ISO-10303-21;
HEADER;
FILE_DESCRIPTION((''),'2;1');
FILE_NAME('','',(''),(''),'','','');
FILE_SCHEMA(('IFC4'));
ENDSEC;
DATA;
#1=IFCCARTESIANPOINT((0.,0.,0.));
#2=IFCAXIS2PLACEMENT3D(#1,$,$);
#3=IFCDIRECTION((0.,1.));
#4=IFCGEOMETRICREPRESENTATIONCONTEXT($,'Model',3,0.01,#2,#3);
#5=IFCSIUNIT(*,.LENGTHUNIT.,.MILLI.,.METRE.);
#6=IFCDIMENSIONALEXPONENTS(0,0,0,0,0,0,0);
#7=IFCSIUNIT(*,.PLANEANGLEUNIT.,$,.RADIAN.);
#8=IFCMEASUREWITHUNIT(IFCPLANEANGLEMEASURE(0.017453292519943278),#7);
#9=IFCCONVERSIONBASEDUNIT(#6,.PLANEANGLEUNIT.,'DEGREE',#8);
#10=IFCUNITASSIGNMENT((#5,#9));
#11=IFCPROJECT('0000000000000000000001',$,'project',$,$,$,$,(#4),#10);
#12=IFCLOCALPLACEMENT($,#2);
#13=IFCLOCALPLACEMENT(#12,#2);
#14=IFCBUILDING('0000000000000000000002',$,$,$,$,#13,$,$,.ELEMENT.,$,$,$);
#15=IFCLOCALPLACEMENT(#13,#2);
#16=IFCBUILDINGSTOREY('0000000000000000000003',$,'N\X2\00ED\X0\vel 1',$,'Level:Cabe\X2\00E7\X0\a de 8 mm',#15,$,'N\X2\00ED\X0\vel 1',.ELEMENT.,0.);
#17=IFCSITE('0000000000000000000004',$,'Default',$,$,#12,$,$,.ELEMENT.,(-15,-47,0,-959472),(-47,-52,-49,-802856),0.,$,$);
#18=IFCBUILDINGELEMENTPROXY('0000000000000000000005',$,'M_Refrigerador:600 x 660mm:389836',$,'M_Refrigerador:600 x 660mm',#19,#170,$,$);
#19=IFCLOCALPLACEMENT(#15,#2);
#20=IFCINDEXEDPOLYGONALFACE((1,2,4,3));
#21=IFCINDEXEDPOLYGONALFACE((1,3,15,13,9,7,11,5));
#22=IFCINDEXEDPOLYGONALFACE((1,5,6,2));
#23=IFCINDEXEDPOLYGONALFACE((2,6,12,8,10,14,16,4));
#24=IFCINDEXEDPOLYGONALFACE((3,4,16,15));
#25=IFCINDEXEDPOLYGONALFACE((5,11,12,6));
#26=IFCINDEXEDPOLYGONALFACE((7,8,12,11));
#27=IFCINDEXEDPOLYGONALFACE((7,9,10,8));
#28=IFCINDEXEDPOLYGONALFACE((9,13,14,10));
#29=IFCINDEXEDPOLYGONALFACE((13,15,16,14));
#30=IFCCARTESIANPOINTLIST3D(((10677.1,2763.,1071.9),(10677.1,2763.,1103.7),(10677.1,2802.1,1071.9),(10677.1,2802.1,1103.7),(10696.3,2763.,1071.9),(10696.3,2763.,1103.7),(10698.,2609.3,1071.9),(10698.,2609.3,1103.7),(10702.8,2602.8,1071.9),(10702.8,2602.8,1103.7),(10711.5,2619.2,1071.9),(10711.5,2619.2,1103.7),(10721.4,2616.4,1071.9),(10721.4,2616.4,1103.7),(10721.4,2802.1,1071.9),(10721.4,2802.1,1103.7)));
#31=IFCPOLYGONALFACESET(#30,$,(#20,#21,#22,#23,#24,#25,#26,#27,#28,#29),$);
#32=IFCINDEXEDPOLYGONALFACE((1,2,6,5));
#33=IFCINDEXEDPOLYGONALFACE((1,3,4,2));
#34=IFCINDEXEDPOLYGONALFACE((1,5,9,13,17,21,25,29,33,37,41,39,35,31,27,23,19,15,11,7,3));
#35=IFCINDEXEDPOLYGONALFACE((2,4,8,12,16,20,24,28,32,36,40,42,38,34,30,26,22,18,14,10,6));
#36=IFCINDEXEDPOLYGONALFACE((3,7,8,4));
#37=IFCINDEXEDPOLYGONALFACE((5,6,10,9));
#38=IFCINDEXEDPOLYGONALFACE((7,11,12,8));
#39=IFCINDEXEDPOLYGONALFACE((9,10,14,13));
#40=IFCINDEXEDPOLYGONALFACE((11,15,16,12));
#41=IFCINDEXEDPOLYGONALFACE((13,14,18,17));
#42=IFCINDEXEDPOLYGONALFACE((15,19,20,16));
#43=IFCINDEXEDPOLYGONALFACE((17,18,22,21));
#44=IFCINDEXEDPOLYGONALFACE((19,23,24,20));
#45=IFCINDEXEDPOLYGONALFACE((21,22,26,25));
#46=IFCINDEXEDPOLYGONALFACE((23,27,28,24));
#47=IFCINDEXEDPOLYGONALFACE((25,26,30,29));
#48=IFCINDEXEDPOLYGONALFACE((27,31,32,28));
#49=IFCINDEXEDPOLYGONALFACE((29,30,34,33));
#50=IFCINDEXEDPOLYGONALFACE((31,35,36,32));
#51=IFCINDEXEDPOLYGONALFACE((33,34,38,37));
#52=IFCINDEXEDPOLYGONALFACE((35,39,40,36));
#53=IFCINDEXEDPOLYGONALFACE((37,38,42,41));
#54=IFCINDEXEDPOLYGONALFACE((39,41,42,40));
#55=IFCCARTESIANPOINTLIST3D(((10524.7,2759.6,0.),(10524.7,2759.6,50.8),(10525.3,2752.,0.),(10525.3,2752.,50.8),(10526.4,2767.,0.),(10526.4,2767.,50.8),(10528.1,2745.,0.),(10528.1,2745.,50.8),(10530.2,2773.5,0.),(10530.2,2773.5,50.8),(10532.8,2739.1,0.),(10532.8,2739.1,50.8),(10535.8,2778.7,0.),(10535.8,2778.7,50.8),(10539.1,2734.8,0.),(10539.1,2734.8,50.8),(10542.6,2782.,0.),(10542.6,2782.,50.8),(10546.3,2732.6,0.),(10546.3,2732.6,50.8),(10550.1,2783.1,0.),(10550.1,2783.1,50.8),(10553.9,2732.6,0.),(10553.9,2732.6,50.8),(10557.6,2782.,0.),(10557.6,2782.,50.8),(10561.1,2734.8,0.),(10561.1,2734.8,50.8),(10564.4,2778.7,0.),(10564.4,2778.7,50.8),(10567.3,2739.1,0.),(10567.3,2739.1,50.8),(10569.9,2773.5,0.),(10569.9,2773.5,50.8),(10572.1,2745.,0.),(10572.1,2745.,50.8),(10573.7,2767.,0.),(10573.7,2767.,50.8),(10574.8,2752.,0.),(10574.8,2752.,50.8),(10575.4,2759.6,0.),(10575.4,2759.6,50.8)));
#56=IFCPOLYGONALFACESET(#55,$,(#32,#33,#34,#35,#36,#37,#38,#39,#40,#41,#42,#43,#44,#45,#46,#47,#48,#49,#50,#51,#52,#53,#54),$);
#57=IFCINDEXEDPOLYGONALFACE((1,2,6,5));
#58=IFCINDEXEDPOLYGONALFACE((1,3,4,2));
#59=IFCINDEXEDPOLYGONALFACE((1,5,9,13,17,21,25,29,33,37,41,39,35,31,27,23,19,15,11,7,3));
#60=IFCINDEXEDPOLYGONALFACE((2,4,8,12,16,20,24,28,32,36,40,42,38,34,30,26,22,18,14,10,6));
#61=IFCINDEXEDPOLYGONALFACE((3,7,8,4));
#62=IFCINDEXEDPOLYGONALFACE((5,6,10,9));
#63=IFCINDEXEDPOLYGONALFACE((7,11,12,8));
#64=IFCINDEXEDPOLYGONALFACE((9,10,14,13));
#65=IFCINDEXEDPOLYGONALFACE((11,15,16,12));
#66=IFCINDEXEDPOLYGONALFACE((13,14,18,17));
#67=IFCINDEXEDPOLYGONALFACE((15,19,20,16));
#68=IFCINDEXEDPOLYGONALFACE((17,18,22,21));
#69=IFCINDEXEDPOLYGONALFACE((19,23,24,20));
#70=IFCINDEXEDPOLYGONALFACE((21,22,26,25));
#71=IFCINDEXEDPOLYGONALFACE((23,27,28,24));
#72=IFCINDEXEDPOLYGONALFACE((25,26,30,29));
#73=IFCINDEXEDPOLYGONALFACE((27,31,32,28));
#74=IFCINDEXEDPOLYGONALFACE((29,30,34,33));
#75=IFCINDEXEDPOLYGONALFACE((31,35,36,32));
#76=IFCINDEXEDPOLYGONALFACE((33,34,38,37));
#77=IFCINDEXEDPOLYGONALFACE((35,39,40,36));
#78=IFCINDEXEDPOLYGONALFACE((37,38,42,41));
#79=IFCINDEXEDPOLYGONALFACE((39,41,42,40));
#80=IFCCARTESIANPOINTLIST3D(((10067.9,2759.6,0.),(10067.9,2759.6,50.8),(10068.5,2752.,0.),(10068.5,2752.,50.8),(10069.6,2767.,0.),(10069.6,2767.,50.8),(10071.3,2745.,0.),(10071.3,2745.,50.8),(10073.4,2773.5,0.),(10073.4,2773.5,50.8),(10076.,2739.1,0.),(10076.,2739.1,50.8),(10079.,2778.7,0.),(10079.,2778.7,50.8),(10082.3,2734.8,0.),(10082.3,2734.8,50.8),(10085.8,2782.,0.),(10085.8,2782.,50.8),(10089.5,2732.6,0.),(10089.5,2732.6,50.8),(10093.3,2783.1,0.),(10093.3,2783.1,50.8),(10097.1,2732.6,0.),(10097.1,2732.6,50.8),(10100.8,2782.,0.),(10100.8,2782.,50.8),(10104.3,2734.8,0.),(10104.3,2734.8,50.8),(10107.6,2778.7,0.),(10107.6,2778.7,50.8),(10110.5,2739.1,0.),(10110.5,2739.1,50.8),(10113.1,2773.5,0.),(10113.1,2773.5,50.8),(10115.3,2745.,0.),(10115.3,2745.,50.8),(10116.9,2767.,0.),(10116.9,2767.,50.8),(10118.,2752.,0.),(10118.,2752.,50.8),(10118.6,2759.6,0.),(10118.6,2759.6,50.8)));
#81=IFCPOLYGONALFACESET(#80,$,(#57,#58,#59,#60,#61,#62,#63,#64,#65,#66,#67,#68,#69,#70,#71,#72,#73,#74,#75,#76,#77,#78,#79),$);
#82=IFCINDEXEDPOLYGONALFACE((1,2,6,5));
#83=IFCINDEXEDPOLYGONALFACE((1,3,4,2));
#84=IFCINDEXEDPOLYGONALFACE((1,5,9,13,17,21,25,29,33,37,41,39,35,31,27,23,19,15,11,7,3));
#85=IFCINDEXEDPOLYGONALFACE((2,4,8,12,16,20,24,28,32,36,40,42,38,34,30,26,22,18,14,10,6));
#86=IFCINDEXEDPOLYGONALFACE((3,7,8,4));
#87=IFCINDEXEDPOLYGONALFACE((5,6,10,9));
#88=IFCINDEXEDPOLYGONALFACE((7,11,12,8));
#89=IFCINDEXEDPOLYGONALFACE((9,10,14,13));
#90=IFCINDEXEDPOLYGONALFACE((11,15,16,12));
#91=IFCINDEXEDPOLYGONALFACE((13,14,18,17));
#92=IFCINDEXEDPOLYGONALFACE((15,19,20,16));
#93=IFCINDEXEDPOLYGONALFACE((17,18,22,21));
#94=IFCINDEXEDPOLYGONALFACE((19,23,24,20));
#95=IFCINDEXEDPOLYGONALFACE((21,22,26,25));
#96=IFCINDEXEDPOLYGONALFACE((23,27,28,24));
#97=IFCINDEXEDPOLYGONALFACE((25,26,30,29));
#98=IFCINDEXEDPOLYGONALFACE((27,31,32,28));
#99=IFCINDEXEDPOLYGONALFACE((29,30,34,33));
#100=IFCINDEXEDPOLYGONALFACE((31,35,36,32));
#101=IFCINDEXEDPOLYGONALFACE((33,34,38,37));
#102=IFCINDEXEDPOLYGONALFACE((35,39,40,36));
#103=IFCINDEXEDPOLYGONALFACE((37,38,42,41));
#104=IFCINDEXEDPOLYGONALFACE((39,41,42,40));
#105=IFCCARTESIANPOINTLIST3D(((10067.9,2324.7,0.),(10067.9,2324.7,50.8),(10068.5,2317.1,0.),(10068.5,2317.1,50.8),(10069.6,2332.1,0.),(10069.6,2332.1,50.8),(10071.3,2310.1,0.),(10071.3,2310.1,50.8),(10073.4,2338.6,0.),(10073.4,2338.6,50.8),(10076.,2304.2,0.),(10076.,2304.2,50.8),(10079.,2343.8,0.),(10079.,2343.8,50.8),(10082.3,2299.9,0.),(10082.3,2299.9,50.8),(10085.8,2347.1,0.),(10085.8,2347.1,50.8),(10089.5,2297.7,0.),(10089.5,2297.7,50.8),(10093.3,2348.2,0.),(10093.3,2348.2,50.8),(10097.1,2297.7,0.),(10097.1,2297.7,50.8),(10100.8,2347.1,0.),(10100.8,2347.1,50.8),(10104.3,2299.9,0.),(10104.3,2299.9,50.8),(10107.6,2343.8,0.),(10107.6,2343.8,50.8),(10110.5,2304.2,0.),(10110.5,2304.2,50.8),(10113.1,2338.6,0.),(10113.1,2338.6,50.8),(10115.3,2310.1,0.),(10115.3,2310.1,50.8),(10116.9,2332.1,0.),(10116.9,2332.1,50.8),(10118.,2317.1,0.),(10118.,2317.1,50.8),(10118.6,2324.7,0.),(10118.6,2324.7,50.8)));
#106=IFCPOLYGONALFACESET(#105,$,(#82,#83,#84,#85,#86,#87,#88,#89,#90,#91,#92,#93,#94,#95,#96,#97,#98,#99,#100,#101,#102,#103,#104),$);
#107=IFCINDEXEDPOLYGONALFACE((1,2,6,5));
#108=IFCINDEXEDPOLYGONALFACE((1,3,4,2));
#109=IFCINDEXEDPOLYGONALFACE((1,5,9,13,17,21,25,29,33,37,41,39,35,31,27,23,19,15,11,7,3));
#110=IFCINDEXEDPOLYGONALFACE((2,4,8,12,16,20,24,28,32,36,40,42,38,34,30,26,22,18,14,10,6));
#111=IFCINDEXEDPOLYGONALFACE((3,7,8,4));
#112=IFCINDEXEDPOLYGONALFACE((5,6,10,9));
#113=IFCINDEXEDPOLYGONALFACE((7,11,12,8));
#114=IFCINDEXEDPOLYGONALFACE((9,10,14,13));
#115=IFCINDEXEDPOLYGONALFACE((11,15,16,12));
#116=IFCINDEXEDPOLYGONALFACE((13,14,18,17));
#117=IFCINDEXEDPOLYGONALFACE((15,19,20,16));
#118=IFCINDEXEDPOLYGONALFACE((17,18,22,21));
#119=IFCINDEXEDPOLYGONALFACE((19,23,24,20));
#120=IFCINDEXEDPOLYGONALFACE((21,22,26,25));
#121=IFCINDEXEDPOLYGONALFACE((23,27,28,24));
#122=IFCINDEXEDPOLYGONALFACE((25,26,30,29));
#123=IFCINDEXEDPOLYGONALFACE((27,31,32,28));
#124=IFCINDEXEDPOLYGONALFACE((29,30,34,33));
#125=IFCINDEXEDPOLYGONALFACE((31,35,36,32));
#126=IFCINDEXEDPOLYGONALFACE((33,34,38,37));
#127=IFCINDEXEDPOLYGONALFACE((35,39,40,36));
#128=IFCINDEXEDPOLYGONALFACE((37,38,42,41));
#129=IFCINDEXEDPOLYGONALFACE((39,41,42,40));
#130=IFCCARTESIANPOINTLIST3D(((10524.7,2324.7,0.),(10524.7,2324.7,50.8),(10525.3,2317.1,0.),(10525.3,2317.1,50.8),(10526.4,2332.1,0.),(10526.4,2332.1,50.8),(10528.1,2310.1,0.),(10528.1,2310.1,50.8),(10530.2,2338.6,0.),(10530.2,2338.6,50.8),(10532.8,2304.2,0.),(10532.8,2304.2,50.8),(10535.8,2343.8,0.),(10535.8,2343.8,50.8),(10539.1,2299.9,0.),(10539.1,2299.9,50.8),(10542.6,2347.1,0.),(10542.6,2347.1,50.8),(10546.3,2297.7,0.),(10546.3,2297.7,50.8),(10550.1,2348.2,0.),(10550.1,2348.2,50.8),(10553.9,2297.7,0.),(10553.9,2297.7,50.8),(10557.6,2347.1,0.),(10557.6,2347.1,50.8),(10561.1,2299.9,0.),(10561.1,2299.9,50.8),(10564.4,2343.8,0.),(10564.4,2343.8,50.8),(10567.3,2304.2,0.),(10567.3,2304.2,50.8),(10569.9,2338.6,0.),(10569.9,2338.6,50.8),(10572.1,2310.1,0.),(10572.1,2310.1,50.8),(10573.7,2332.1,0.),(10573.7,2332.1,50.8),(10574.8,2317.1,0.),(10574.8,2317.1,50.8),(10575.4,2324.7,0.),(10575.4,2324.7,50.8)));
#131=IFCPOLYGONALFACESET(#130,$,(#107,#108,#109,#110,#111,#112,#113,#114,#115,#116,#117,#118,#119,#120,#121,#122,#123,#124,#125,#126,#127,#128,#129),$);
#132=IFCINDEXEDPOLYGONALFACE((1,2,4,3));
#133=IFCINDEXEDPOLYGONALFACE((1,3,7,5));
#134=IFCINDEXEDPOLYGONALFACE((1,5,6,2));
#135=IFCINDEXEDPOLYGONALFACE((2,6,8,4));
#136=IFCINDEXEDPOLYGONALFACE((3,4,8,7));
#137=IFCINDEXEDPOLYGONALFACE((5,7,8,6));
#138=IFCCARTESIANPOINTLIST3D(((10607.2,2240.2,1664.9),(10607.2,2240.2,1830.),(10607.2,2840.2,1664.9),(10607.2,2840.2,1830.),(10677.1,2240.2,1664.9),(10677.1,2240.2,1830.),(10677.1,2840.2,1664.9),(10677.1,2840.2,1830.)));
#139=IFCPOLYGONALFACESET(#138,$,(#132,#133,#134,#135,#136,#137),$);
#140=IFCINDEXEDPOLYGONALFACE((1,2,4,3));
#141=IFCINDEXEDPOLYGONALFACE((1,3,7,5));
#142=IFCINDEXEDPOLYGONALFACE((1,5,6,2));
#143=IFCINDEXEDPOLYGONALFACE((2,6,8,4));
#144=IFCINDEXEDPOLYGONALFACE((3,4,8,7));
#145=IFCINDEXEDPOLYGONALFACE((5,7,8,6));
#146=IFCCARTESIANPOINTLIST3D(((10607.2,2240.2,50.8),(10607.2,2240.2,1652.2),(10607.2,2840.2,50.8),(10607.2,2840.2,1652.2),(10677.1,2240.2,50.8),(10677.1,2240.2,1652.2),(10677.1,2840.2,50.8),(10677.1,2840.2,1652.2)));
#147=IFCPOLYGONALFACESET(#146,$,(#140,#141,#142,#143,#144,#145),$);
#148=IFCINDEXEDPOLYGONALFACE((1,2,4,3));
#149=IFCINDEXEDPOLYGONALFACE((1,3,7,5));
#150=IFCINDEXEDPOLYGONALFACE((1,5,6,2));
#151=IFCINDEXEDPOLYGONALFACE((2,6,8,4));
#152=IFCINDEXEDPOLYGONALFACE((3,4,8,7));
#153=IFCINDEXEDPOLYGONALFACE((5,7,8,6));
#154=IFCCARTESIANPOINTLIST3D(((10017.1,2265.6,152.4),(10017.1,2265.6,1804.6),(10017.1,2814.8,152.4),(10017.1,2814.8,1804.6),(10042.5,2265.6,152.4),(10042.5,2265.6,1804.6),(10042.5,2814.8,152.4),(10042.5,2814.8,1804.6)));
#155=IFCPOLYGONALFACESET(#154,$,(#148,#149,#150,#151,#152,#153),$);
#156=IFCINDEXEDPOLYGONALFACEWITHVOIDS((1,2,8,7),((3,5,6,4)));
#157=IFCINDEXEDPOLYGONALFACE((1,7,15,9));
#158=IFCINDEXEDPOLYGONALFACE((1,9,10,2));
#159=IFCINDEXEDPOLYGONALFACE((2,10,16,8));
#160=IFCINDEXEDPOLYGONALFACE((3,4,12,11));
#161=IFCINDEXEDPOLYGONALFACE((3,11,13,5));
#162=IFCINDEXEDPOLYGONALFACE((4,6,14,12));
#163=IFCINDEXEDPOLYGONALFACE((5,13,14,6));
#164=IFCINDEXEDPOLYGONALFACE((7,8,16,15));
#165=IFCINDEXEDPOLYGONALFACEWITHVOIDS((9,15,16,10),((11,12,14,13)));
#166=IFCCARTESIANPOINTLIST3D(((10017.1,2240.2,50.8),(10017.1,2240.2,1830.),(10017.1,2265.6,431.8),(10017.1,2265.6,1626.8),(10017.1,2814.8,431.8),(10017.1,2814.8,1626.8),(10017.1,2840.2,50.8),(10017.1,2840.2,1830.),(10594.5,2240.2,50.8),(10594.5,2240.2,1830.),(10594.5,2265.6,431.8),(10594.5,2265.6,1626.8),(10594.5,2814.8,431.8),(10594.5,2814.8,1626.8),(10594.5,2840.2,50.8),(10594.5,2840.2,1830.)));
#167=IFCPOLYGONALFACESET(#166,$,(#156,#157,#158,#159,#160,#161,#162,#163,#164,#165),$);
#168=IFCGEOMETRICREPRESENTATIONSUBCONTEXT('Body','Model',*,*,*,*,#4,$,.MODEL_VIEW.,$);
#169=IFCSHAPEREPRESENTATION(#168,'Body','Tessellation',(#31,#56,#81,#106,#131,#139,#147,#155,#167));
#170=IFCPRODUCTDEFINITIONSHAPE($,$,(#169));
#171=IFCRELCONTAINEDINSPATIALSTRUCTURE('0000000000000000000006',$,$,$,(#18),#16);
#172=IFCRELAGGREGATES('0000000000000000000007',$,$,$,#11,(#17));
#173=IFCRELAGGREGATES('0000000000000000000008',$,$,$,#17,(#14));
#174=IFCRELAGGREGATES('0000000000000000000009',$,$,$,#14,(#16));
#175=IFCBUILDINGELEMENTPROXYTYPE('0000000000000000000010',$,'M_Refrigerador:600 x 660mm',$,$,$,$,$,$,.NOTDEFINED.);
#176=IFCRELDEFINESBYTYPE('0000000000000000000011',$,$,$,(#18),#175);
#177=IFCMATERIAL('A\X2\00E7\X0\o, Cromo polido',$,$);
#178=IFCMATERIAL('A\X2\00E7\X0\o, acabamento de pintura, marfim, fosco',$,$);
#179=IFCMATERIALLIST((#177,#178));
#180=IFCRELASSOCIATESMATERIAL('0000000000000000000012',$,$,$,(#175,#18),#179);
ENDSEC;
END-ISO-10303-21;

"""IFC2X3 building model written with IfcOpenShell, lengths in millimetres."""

from ifc_helpers import new_model, entity, si_unit, converted_unit, direction, frame, frame_2d, origin, origin_2d_with_axis, place, context, subcontext, project, spatial, polyline, rectangle, circle, outline, extrude, source, transform, mapped, material, material_list, type_object, type_shapes, element, save


model = new_model("IFC2X3")

# Units and contexts
model_context = context("Model", 3, precision=0.01, world=origin(), true_north=direction((0.0, 1.0)))
body_context = subcontext(model_context, "Body", "Model", "MODEL_VIEW")
ifc_project = project(units=[si_unit("LENGTHUNIT", "METRE", prefix="MILLI"), converted_unit("PLANEANGLEUNIT", "DEGREE", entity("IfcPlaneAngleMeasure", 0.017453292519943278), si_unit("PLANEANGLEUNIT", "RADIAN"), dimensions=[0, 0, 0, 0, 0, 0, 0])], contexts=[model_context])

# Site, building, storey
site_placement = place(None, origin())
site = spatial("IfcSite", under=ifc_project, at=site_placement, Name="Default", CompositionType="ELEMENT", RefLatitude=(-15, -47, 0, -959472), RefLongitude=(-47, -52, -49, -802856), RefElevation=0.0)
building_placement = place(site_placement, origin())
building = spatial("IfcBuilding", under=site, at=building_placement, CompositionType="ELEMENT")
storey_placement = place(building_placement, origin())
storey = spatial("IfcBuildingStorey", under=building, at=storey_placement, Name="Nível 1", ObjectType="Level:Cabeça de 8 mm", LongName="Nível 1", CompositionType="ELEMENT", Elevation=0.0)

# Shared definitions
ifc_material_1 = material(Name="Aço, Cromo polido")

# Building element proxy
ifc_material_2 = material(Name="Aço, acabamento de pintura, marfim, fosco")
ifc_material_list_1 = material_list([ifc_material_1, ifc_material_2])
building_element_proxy_type_1 = type_object("IfcBuildingElementProxyType", Name="M_Refrigerador:600 x 660mm", PredefinedType="NOTDEFINED", material=ifc_material_list_1)
shared_shape_1 = source(origin(), body_context, "Body", "SweptSolid", [
    extrude(outline(polyline([(-20.7, -104.9), (23.6, -104.9), (23.6, -65.7), (4.4, -65.7), (-10.8, 78.0), (2.7, 88.0), (-2.1, 94.5), (-20.7, 80.8), (-20.7, -104.9)])), frame((103.2, -387.4, 1071.9), z_axis=(0.0, 0.0, 1.0), x_axis=(0.0, 1.0, 0.0)), (0.0, 0.0, 1.0), 31.7),
    extrude(circle(Radius=25.4, at=origin_2d_with_axis()), frame((163.6, -236.8, 0.0)), (0.0, 0.0, 1.0), 50.8),
    extrude(circle(Radius=25.4, at=origin_2d_with_axis()), frame((163.6, 220.0, 0.0)), (0.0, 0.0, 1.0), 50.8),
    extrude(circle(Radius=25.4, at=origin_2d_with_axis()), frame((-271.3, 220.0, 0.0)), (0.0, 0.0, 1.0), 50.8),
    extrude(circle(Radius=25.4, at=frame_2d((0.0, 0.0), x_axis=(1.0, 0.0))), frame((-271.3, -236.8, 0.0)), (0.0, 0.0, 1.0), 50.8),
    extrude(rectangle(XDim=69.8, YDim=600.0, at=frame_2d((0.0, 0.0), x_axis=(1.0, 0.0))), frame((-53.8, -328.9, 1664.9), z_axis=(0.0, 0.0, 1.0), x_axis=(0.0, 1.0, 0.0)), (0.0, 0.0, 1.0), 165.1),
    extrude(rectangle(XDim=69.8, YDim=600.0, at=frame_2d((0.0, 0.0), x_axis=(1.0, 0.0))), frame((-53.8, -328.9, 50.8), z_axis=(0.0, 0.0, 1.0), x_axis=(0.0, 1.0, 0.0)), (0.0, 0.0, 1.0), 1601.4),
    extrude(rectangle(XDim=25.4, YDim=549.2, at=origin_2d_with_axis()), frame((-53.8, 283.5, 152.4), z_axis=(0.0, 0.0, 1.0), x_axis=(0.0, 1.0, 0.0)), (0.0, 0.0, 1.0), 1652.2),
    extrude(outline(polyline([(-889.6, -300.0), (889.6, -300.0), (889.6, 300.0), (-889.6, 300.0), (-889.6, -300.0)]), holes=[polyline([(-686.4, -274.6), (-686.4, 274.6), (508.6, 274.6), (508.6, -274.6), (-686.4, -274.6)])]), frame((-53.8, -281.2, 940.4), z_axis=(0.0, 1.0, 0.0), x_axis=(0.0, 0.0, -1.0)), (0.0, 0.0, 1.0), 577.4),
])
type_shapes(building_element_proxy_type_1, [shared_shape_1])
proxy_1_placement = place(storey_placement, frame((10313.3, 2594.0, 0.0), z_axis=(0.0, 0.0, 1.0), x_axis=(0.0, 1.0, 0.0)))
element("IfcBuildingElementProxy", 1, at=proxy_1_placement, inside=storey, type_object=building_element_proxy_type_1, material=ifc_material_list_1, Name="M_Refrigerador:600 x 660mm:389836", ObjectType="M_Refrigerador:600 x 660mm", context=body_context, shape_type="MappedRepresentation", body=[
    mapped(shared_shape_1, transform((0.0, 0.0, 0.0), scale=1.0)),
])

save(model, "model.ifc")
